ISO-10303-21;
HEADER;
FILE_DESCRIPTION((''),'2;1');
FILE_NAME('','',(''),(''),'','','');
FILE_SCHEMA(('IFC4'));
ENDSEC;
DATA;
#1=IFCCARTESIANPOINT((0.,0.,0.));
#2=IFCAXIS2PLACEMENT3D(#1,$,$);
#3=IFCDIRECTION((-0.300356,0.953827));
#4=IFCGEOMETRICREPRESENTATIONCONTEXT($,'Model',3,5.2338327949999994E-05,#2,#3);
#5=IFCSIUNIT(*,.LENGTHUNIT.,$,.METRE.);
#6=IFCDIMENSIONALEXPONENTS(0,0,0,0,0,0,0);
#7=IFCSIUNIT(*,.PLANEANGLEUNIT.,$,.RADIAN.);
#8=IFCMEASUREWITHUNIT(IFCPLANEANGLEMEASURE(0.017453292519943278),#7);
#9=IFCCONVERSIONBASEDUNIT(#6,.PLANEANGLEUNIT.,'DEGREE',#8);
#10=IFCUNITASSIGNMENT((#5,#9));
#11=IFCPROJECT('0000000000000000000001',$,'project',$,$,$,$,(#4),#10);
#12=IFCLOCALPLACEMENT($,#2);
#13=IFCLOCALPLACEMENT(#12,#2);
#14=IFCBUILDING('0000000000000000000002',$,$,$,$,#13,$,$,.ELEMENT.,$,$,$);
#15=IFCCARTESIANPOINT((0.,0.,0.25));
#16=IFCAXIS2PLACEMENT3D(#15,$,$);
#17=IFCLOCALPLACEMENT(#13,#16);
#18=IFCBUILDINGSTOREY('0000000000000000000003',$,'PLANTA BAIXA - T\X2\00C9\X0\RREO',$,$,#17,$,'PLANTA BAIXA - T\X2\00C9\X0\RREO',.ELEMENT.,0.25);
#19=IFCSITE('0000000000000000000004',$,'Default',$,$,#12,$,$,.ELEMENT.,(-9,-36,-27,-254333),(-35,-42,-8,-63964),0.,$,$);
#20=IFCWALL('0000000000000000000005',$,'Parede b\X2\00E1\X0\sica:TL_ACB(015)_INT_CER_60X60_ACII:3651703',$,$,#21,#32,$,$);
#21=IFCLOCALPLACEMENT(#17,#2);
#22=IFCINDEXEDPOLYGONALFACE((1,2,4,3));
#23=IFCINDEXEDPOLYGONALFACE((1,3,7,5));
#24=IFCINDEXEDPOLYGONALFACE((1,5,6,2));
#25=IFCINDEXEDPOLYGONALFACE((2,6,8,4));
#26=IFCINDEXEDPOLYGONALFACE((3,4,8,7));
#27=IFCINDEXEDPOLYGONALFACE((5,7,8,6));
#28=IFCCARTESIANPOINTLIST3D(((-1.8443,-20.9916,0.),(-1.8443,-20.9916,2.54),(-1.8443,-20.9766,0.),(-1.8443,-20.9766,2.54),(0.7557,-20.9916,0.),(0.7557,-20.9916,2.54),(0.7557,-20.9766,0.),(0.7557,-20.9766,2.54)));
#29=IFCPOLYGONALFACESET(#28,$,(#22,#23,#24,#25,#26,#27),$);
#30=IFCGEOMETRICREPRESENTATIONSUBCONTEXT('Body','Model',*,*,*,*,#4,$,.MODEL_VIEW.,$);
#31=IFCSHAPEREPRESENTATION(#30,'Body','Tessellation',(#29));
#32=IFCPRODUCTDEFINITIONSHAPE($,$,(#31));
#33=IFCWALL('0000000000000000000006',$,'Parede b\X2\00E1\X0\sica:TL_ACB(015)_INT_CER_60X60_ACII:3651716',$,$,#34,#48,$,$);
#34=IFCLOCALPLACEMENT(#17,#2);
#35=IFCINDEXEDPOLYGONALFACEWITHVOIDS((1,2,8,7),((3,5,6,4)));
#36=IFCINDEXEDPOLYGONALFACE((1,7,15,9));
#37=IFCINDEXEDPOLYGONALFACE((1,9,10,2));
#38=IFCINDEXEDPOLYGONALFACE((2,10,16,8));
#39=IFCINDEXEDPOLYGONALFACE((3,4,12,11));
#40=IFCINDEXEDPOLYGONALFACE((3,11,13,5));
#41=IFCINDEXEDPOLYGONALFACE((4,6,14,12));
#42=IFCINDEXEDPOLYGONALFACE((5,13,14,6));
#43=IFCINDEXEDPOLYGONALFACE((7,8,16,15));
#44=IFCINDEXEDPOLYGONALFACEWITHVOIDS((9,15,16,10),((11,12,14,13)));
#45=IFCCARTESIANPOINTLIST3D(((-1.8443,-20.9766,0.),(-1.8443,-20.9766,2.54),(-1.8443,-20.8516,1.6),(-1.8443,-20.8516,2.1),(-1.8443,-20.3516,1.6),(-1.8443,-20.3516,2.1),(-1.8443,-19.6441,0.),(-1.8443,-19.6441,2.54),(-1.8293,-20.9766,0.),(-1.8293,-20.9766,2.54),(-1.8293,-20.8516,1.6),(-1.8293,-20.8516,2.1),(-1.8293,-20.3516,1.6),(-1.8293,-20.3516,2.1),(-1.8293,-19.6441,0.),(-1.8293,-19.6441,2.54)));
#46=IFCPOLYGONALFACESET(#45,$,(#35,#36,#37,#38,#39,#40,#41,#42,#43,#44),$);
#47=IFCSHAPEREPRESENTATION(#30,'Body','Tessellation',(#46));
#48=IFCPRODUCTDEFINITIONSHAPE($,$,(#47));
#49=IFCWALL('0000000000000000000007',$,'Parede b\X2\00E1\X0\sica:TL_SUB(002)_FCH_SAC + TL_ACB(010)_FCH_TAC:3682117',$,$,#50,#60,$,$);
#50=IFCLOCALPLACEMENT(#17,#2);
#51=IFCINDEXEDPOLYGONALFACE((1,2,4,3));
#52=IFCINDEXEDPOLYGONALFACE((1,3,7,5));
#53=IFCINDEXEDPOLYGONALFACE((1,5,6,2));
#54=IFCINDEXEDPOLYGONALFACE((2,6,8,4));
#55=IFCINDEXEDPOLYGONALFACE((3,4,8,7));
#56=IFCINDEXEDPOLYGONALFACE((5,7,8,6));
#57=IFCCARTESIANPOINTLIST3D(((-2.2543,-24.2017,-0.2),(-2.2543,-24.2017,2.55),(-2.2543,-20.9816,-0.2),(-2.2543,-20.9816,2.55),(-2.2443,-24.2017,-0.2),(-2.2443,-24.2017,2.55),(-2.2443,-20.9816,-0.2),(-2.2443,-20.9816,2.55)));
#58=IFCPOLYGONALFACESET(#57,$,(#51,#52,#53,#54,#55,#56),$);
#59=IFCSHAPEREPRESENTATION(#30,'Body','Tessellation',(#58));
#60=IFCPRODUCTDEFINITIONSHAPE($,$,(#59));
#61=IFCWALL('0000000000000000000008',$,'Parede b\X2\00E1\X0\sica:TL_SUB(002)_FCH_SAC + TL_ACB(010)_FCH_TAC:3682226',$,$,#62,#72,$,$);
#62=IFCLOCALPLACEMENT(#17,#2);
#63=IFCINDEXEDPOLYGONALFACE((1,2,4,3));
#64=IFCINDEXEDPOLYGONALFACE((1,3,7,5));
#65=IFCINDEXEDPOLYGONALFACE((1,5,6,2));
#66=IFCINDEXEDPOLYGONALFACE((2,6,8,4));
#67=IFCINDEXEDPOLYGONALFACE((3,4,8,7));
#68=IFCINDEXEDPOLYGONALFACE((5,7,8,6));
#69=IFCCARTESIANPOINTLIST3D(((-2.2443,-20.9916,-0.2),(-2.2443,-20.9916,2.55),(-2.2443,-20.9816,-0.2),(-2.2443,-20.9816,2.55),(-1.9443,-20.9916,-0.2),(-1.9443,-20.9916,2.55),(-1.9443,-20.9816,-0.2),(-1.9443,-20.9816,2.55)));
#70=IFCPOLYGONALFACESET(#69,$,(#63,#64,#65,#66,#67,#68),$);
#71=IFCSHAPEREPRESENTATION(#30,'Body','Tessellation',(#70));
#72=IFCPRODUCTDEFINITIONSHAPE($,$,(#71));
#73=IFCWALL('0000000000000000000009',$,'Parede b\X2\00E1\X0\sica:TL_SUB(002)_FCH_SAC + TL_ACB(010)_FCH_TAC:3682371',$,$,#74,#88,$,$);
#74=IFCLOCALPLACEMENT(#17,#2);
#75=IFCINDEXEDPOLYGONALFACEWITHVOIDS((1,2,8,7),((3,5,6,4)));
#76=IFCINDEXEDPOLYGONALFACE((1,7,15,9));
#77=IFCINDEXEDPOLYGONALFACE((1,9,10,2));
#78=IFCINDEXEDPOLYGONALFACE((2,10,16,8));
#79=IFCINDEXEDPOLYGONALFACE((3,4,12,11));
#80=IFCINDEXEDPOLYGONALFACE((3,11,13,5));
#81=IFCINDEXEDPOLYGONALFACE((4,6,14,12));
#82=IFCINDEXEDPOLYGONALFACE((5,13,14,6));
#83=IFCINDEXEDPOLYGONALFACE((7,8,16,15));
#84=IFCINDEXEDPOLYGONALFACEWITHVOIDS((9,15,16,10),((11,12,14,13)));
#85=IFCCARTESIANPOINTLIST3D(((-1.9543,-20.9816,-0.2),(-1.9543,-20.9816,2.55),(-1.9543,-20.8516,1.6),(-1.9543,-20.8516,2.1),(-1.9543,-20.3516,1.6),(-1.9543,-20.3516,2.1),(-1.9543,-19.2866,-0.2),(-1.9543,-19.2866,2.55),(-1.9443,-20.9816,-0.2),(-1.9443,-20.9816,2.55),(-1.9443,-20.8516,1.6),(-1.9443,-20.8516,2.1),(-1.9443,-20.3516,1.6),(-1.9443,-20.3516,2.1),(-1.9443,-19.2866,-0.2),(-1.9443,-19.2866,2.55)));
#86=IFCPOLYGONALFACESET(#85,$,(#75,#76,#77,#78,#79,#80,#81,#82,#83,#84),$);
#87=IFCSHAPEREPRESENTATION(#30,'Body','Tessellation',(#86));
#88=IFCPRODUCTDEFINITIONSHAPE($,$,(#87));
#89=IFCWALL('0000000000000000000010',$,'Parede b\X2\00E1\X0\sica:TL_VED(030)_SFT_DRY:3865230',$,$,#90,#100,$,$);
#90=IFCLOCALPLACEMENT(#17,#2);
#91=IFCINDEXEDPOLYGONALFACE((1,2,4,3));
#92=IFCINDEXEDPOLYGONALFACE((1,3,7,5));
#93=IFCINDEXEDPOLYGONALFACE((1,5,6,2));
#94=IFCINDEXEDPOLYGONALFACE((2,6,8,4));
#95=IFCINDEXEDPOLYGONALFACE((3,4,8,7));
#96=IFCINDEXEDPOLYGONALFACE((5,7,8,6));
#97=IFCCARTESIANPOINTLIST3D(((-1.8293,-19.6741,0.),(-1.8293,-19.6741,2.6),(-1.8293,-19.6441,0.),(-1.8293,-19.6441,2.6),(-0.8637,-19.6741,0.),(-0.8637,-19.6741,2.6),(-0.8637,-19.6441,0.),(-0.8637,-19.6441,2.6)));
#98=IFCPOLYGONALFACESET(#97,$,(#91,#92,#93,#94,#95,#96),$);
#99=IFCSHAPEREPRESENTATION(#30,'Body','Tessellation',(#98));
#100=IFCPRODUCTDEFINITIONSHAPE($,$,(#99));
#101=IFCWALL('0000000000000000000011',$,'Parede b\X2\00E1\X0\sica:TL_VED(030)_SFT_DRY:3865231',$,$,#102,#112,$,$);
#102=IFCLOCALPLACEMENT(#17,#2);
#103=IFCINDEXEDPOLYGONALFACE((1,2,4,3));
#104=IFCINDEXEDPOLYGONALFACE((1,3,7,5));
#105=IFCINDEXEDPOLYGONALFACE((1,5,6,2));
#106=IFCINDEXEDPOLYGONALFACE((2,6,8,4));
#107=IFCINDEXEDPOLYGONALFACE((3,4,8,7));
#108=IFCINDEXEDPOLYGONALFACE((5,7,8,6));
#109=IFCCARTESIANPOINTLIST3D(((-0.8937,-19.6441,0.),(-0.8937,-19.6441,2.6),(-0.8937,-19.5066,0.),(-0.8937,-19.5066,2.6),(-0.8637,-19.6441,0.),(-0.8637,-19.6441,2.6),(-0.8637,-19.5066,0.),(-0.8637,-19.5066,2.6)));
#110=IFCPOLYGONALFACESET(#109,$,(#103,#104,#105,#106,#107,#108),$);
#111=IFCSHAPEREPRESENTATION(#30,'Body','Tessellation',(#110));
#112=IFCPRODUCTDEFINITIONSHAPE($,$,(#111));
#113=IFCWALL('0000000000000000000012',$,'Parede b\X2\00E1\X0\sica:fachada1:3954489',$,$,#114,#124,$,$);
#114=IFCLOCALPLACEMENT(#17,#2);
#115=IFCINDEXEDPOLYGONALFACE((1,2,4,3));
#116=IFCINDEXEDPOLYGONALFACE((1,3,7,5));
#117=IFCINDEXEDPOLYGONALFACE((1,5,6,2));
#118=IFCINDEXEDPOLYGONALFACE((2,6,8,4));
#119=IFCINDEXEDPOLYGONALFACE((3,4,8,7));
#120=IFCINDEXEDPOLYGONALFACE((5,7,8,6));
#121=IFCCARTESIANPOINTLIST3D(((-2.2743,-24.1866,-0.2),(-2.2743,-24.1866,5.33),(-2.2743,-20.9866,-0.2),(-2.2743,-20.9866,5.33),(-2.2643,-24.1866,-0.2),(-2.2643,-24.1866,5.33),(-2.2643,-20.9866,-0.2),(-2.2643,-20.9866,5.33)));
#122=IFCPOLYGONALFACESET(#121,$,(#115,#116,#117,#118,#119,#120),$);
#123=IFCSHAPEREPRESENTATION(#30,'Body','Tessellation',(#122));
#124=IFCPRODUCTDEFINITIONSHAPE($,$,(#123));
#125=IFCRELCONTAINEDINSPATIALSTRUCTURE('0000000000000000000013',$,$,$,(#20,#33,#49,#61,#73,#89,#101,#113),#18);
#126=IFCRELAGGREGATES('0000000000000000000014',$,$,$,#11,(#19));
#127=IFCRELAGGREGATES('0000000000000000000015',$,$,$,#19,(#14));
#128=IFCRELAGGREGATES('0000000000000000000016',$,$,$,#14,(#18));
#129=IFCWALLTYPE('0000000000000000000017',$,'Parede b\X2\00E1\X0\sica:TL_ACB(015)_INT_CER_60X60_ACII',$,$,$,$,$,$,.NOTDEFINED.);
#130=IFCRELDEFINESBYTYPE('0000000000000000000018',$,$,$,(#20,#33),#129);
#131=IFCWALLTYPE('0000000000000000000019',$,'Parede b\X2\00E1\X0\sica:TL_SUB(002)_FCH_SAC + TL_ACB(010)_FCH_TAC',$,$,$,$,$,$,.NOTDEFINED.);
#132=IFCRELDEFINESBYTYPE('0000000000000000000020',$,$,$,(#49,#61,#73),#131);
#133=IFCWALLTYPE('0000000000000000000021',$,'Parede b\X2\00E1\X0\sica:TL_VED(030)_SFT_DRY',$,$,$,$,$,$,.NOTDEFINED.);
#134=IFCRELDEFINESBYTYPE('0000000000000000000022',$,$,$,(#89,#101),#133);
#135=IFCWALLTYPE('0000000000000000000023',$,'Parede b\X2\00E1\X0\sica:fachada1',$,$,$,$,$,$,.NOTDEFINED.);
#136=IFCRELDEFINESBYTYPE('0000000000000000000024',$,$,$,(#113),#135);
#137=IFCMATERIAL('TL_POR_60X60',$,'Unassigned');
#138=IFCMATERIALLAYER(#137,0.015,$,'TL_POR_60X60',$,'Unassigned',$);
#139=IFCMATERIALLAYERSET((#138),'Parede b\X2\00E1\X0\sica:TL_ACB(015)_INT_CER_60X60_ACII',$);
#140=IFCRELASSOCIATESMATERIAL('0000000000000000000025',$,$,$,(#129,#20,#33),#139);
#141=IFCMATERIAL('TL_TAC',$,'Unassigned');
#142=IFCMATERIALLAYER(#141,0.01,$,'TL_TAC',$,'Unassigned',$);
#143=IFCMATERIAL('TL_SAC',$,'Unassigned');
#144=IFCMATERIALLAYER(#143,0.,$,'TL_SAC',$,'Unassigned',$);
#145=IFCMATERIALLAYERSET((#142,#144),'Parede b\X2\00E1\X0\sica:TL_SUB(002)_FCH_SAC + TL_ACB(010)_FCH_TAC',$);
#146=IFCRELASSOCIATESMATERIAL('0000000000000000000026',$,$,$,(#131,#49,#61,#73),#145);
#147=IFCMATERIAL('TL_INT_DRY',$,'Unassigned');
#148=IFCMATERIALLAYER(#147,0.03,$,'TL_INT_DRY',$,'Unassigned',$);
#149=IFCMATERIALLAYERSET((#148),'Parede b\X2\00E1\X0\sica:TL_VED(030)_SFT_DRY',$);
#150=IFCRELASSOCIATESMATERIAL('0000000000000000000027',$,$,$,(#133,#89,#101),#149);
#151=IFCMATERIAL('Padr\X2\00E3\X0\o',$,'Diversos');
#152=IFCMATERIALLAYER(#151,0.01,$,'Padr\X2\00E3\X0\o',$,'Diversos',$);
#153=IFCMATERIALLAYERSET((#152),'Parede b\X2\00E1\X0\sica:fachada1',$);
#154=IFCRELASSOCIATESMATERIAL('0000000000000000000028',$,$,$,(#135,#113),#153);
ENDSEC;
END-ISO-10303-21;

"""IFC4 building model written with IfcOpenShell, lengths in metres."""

from ifc_helpers import new_model, entity, si_unit, converted_unit, direction, frame, frame_2d, origin, place, context, subcontext, project, spatial, rectangle, extrude, material, layer, layer_set, layer_usage, type_object, element, save


model = new_model("IFC4")

# Units and contexts
model_context = context("Model", 3, precision=5.2338327949999994e-05, world=origin(), true_north=direction((-0.300356, 0.953827)))
body_context = subcontext(model_context, "Body", "Model", "MODEL_VIEW")
ifc_project = project(units=[si_unit("LENGTHUNIT", "METRE"), converted_unit("PLANEANGLEUNIT", "DEGREE", entity("IfcPlaneAngleMeasure", 0.017453292519943278), si_unit("PLANEANGLEUNIT", "RADIAN"), dimensions=[0, 0, 0, 0, 0, 0, 0])], contexts=[model_context])

# Site, building, storey
site_placement = place(None, origin())
site = spatial("IfcSite", under=ifc_project, at=site_placement, Name="Default", CompositionType="ELEMENT", RefLatitude=(-9, -36, -27, -254333), RefLongitude=(-35, -42, -8, -63964), RefElevation=0.0)
building_placement = place(site_placement, origin())
building = spatial("IfcBuilding", under=site, at=building_placement, CompositionType="ELEMENT")
storey_placement = place(building_placement, frame((0.0, 0.0, 0.25)))
storey = spatial("IfcBuildingStorey", under=building, at=storey_placement, Name="PLANTA BAIXA - TÉRREO", LongName="PLANTA BAIXA - TÉRREO", CompositionType="ELEMENT", Elevation=0.25)

# Shared definitions
ifc_material_1 = material(Name="TL_SAC", Category="Unassigned")

# Wall
ifc_material_2 = material(Name="TL_POR_60X60", Category="Unassigned")
ifc_layer_1 = layer(ifc_material_2, 0.015, Name="TL_POR_60X60", Category="Unassigned")
ifc_layer_set_1 = layer_set([ifc_layer_1], Name="Parede básica:TL_ACB(015)_INT_CER_60X60_ACII")
ifc_layer_usage_1 = layer_usage(ifc_layer_set_1, "AXIS2", "NEGATIVE", 0.0075)
wall_type_1 = type_object("IfcWallType", Name="Parede básica:TL_ACB(015)_INT_CER_60X60_ACII", PredefinedType="NOTDEFINED", material=ifc_layer_set_1)
wall_1_placement = place(storey_placement, frame((-1.8443, -20.9841, 0.0)))
element("IfcWall", 1, at=wall_1_placement, inside=storey, type_object=wall_type_1, material=ifc_layer_usage_1, Name="Parede básica:TL_ACB(015)_INT_CER_60X60_ACII:3651703", context=body_context, shape_type="SweptSolid", body=[
    extrude(rectangle(XDim=2.6, YDim=0.015, at=frame_2d((1.3, 0.0), x_axis=(-1.0, 0.0))), origin(), (0.0, 0.0, 1.0), 2.54),
])

# Wall, opening
ifc_layer_usage_2 = layer_usage(ifc_layer_set_1, "AXIS2", "POSITIVE", -0.0075)
wall_2_placement = place(storey_placement, frame((-1.8368, -20.9766, 0.0), z_axis=(0.0, 0.0, 1.0), x_axis=(0.0, 1.0, 0.0)))
wall_2 = element("IfcWall", 2, at=wall_2_placement, inside=storey, type_object=wall_type_1, material=ifc_layer_usage_2, Name="Parede básica:TL_ACB(015)_INT_CER_60X60_ACII:3651716", context=body_context, shape_type="SweptSolid", body=[
    extrude(rectangle(XDim=1.3325, YDim=0.015, at=frame_2d((0.6662, 0.0), x_axis=(-1.0, 0.0))), origin(), (0.0, 0.0, 1.0), 2.54),
])
opening_1_placement = place(wall_2_placement, frame((20.9766, -1.8368, 1.6)))
element("IfcOpeningElement", 3, at=opening_1_placement, cuts=wall_2, PredefinedType="OPENING", context=body_context, shape_type="SweptSolid", body=[
    extrude(rectangle(XDim=0.5, YDim=0.5, at=frame_2d((0.0, 0.0), x_axis=(1.0, 0.0))), frame((-20.6016, 0.4203, 0.25), z_axis=(0.0, 1.0, 0.0), x_axis=(0.0, 0.0, 1.0)), (0.0, 0.0, 1.0), 3.048),
])

# Walls
ifc_material_3 = material(Name="TL_TAC", Category="Unassigned")
ifc_layer_2 = layer(ifc_material_3, 0.01, Name="TL_TAC", Category="Unassigned")
ifc_layer_3 = layer(ifc_material_1, 0.0, Name="TL_SAC", Category="Unassigned")
ifc_layer_set_2 = layer_set([ifc_layer_2, ifc_layer_3], Name="Parede básica:TL_SUB(002)_FCH_SAC + TL_ACB(010)_FCH_TAC")
ifc_layer_usage_3 = layer_usage(ifc_layer_set_2, "AXIS2", "POSITIVE", -0.005)
wall_type_2 = type_object("IfcWallType", Name="Parede básica:TL_SUB(002)_FCH_SAC + TL_ACB(010)_FCH_TAC", PredefinedType="NOTDEFINED", material=ifc_layer_set_2)
wall_3_placement = place(storey_placement, frame((-2.2493, -24.2017, -0.2), z_axis=(0.0, 0.0, 1.0), x_axis=(0.0, 1.0, 0.0)))
element("IfcWall", 4, at=wall_3_placement, inside=storey, type_object=wall_type_2, material=ifc_layer_usage_3, Name="Parede básica:TL_SUB(002)_FCH_SAC + TL_ACB(010)_FCH_TAC:3682117", context=body_context, shape_type="SweptSolid", body=[
    extrude(rectangle(XDim=3.2201, YDim=0.01, at=frame_2d((1.6101, 0.0), x_axis=(-1.0, 0.0))), origin(), (0.0, 0.0, 1.0), 2.75),
])
ifc_layer_usage_4 = layer_usage(ifc_layer_set_2, "AXIS2", "POSITIVE", -0.005)
wall_4_placement = place(storey_placement, frame((-2.2443, -20.9866, -0.2)))
element("IfcWall", 5, at=wall_4_placement, inside=storey, type_object=wall_type_2, material=ifc_layer_usage_4, Name="Parede básica:TL_SUB(002)_FCH_SAC + TL_ACB(010)_FCH_TAC:3682226", context=body_context, shape_type="SweptSolid", body=[
    extrude(rectangle(XDim=0.3, YDim=0.01, at=frame_2d((0.15, 0.0), x_axis=(-1.0, 0.0))), origin(), (0.0, 0.0, 1.0), 2.75),
])

# Wall, opening
ifc_layer_usage_5 = layer_usage(ifc_layer_set_2, "AXIS2", "POSITIVE", -0.005)
wall_5_placement = place(storey_placement, frame((-1.9493, -20.9816, -0.2), z_axis=(0.0, 0.0, 1.0), x_axis=(0.0, 1.0, 0.0)))
wall_5 = element("IfcWall", 6, at=wall_5_placement, inside=storey, type_object=wall_type_2, material=ifc_layer_usage_5, Name="Parede básica:TL_SUB(002)_FCH_SAC + TL_ACB(010)_FCH_TAC:3682371", context=body_context, shape_type="SweptSolid", body=[
    extrude(rectangle(XDim=1.695, YDim=0.01, at=frame_2d((0.8475, 0.0), x_axis=(-1.0, 0.0))), origin(), (0.0, 0.0, 1.0), 2.75),
])
opening_2_placement = place(wall_5_placement, frame((20.9816, -1.9493, 1.8)))
element("IfcOpeningElement", 7, at=opening_2_placement, cuts=wall_5, PredefinedType="OPENING", context=body_context, shape_type="SweptSolid", body=[
    extrude(rectangle(XDim=0.5, YDim=0.5, at=frame_2d((0.0, 0.0), x_axis=(1.0, 0.0))), frame((-20.6016, 0.4203, 0.25), z_axis=(0.0, 1.0, 0.0), x_axis=(0.0, 0.0, 1.0)), (0.0, 0.0, 1.0), 3.048),
])

# Walls
ifc_material_4 = material(Name="TL_INT_DRY", Category="Unassigned")
ifc_layer_4 = layer(ifc_material_4, 0.03, Name="TL_INT_DRY", Category="Unassigned")
ifc_layer_set_3 = layer_set([ifc_layer_4], Name="Parede básica:TL_VED(030)_SFT_DRY")
ifc_layer_usage_6 = layer_usage(ifc_layer_set_3, "AXIS2", "POSITIVE", -0.015)
wall_type_3 = type_object("IfcWallType", Name="Parede básica:TL_VED(030)_SFT_DRY", PredefinedType="NOTDEFINED", material=ifc_layer_set_3)
wall_6_placement = place(storey_placement, frame((-1.8293, -19.6591, 0.0)))
element("IfcWall", 8, at=wall_6_placement, inside=storey, type_object=wall_type_3, material=ifc_layer_usage_6, Name="Parede básica:TL_VED(030)_SFT_DRY:3865230", context=body_context, shape_type="SweptSolid", body=[
    extrude(rectangle(XDim=0.9655, YDim=0.03, at=frame_2d((0.4828, 0.0), x_axis=(-1.0, 0.0))), origin(), (0.0, 0.0, 1.0), 2.6),
])
ifc_layer_usage_7 = layer_usage(ifc_layer_set_3, "AXIS2", "POSITIVE", -0.015)
wall_7_placement = place(storey_placement, frame((-0.8787, -19.6441, 0.0), z_axis=(0.0, 0.0, 1.0), x_axis=(0.0, 1.0, 0.0)))
element("IfcWall", 9, at=wall_7_placement, inside=storey, type_object=wall_type_3, material=ifc_layer_usage_7, Name="Parede básica:TL_VED(030)_SFT_DRY:3865231", context=body_context, shape_type="SweptSolid", body=[
    extrude(rectangle(XDim=0.1375, YDim=0.03, at=frame_2d((0.0688, 0.0), x_axis=(-1.0, 0.0))), origin(), (0.0, 0.0, 1.0), 2.6),
])
ifc_material_5 = material(Name="Padrão", Category="Diversos")
ifc_layer_5 = layer(ifc_material_5, 0.01, Name="Padrão", Category="Diversos")
ifc_layer_set_4 = layer_set([ifc_layer_5], Name="Parede básica:fachada1")
ifc_layer_usage_8 = layer_usage(ifc_layer_set_4, "AXIS2", "NEGATIVE", 0.005)
wall_type_4 = type_object("IfcWallType", Name="Parede básica:fachada1", PredefinedType="NOTDEFINED", material=ifc_layer_set_4)
wall_8_placement = place(storey_placement, frame((-2.2693, -20.9866, -0.2), z_axis=(0.0, 0.0, 1.0), x_axis=(0.0, -1.0, 0.0)))
element("IfcWall", 10, at=wall_8_placement, inside=storey, type_object=wall_type_4, material=ifc_layer_usage_8, Name="Parede básica:fachada1:3954489", context=body_context, shape_type="SweptSolid", body=[
    extrude(rectangle(XDim=3.2, YDim=0.01, at=frame_2d((1.6, 0.0), x_axis=(-1.0, 0.0))), origin(), (0.0, 0.0, 1.0), 5.53),
])

save(model, "model.ifc")
